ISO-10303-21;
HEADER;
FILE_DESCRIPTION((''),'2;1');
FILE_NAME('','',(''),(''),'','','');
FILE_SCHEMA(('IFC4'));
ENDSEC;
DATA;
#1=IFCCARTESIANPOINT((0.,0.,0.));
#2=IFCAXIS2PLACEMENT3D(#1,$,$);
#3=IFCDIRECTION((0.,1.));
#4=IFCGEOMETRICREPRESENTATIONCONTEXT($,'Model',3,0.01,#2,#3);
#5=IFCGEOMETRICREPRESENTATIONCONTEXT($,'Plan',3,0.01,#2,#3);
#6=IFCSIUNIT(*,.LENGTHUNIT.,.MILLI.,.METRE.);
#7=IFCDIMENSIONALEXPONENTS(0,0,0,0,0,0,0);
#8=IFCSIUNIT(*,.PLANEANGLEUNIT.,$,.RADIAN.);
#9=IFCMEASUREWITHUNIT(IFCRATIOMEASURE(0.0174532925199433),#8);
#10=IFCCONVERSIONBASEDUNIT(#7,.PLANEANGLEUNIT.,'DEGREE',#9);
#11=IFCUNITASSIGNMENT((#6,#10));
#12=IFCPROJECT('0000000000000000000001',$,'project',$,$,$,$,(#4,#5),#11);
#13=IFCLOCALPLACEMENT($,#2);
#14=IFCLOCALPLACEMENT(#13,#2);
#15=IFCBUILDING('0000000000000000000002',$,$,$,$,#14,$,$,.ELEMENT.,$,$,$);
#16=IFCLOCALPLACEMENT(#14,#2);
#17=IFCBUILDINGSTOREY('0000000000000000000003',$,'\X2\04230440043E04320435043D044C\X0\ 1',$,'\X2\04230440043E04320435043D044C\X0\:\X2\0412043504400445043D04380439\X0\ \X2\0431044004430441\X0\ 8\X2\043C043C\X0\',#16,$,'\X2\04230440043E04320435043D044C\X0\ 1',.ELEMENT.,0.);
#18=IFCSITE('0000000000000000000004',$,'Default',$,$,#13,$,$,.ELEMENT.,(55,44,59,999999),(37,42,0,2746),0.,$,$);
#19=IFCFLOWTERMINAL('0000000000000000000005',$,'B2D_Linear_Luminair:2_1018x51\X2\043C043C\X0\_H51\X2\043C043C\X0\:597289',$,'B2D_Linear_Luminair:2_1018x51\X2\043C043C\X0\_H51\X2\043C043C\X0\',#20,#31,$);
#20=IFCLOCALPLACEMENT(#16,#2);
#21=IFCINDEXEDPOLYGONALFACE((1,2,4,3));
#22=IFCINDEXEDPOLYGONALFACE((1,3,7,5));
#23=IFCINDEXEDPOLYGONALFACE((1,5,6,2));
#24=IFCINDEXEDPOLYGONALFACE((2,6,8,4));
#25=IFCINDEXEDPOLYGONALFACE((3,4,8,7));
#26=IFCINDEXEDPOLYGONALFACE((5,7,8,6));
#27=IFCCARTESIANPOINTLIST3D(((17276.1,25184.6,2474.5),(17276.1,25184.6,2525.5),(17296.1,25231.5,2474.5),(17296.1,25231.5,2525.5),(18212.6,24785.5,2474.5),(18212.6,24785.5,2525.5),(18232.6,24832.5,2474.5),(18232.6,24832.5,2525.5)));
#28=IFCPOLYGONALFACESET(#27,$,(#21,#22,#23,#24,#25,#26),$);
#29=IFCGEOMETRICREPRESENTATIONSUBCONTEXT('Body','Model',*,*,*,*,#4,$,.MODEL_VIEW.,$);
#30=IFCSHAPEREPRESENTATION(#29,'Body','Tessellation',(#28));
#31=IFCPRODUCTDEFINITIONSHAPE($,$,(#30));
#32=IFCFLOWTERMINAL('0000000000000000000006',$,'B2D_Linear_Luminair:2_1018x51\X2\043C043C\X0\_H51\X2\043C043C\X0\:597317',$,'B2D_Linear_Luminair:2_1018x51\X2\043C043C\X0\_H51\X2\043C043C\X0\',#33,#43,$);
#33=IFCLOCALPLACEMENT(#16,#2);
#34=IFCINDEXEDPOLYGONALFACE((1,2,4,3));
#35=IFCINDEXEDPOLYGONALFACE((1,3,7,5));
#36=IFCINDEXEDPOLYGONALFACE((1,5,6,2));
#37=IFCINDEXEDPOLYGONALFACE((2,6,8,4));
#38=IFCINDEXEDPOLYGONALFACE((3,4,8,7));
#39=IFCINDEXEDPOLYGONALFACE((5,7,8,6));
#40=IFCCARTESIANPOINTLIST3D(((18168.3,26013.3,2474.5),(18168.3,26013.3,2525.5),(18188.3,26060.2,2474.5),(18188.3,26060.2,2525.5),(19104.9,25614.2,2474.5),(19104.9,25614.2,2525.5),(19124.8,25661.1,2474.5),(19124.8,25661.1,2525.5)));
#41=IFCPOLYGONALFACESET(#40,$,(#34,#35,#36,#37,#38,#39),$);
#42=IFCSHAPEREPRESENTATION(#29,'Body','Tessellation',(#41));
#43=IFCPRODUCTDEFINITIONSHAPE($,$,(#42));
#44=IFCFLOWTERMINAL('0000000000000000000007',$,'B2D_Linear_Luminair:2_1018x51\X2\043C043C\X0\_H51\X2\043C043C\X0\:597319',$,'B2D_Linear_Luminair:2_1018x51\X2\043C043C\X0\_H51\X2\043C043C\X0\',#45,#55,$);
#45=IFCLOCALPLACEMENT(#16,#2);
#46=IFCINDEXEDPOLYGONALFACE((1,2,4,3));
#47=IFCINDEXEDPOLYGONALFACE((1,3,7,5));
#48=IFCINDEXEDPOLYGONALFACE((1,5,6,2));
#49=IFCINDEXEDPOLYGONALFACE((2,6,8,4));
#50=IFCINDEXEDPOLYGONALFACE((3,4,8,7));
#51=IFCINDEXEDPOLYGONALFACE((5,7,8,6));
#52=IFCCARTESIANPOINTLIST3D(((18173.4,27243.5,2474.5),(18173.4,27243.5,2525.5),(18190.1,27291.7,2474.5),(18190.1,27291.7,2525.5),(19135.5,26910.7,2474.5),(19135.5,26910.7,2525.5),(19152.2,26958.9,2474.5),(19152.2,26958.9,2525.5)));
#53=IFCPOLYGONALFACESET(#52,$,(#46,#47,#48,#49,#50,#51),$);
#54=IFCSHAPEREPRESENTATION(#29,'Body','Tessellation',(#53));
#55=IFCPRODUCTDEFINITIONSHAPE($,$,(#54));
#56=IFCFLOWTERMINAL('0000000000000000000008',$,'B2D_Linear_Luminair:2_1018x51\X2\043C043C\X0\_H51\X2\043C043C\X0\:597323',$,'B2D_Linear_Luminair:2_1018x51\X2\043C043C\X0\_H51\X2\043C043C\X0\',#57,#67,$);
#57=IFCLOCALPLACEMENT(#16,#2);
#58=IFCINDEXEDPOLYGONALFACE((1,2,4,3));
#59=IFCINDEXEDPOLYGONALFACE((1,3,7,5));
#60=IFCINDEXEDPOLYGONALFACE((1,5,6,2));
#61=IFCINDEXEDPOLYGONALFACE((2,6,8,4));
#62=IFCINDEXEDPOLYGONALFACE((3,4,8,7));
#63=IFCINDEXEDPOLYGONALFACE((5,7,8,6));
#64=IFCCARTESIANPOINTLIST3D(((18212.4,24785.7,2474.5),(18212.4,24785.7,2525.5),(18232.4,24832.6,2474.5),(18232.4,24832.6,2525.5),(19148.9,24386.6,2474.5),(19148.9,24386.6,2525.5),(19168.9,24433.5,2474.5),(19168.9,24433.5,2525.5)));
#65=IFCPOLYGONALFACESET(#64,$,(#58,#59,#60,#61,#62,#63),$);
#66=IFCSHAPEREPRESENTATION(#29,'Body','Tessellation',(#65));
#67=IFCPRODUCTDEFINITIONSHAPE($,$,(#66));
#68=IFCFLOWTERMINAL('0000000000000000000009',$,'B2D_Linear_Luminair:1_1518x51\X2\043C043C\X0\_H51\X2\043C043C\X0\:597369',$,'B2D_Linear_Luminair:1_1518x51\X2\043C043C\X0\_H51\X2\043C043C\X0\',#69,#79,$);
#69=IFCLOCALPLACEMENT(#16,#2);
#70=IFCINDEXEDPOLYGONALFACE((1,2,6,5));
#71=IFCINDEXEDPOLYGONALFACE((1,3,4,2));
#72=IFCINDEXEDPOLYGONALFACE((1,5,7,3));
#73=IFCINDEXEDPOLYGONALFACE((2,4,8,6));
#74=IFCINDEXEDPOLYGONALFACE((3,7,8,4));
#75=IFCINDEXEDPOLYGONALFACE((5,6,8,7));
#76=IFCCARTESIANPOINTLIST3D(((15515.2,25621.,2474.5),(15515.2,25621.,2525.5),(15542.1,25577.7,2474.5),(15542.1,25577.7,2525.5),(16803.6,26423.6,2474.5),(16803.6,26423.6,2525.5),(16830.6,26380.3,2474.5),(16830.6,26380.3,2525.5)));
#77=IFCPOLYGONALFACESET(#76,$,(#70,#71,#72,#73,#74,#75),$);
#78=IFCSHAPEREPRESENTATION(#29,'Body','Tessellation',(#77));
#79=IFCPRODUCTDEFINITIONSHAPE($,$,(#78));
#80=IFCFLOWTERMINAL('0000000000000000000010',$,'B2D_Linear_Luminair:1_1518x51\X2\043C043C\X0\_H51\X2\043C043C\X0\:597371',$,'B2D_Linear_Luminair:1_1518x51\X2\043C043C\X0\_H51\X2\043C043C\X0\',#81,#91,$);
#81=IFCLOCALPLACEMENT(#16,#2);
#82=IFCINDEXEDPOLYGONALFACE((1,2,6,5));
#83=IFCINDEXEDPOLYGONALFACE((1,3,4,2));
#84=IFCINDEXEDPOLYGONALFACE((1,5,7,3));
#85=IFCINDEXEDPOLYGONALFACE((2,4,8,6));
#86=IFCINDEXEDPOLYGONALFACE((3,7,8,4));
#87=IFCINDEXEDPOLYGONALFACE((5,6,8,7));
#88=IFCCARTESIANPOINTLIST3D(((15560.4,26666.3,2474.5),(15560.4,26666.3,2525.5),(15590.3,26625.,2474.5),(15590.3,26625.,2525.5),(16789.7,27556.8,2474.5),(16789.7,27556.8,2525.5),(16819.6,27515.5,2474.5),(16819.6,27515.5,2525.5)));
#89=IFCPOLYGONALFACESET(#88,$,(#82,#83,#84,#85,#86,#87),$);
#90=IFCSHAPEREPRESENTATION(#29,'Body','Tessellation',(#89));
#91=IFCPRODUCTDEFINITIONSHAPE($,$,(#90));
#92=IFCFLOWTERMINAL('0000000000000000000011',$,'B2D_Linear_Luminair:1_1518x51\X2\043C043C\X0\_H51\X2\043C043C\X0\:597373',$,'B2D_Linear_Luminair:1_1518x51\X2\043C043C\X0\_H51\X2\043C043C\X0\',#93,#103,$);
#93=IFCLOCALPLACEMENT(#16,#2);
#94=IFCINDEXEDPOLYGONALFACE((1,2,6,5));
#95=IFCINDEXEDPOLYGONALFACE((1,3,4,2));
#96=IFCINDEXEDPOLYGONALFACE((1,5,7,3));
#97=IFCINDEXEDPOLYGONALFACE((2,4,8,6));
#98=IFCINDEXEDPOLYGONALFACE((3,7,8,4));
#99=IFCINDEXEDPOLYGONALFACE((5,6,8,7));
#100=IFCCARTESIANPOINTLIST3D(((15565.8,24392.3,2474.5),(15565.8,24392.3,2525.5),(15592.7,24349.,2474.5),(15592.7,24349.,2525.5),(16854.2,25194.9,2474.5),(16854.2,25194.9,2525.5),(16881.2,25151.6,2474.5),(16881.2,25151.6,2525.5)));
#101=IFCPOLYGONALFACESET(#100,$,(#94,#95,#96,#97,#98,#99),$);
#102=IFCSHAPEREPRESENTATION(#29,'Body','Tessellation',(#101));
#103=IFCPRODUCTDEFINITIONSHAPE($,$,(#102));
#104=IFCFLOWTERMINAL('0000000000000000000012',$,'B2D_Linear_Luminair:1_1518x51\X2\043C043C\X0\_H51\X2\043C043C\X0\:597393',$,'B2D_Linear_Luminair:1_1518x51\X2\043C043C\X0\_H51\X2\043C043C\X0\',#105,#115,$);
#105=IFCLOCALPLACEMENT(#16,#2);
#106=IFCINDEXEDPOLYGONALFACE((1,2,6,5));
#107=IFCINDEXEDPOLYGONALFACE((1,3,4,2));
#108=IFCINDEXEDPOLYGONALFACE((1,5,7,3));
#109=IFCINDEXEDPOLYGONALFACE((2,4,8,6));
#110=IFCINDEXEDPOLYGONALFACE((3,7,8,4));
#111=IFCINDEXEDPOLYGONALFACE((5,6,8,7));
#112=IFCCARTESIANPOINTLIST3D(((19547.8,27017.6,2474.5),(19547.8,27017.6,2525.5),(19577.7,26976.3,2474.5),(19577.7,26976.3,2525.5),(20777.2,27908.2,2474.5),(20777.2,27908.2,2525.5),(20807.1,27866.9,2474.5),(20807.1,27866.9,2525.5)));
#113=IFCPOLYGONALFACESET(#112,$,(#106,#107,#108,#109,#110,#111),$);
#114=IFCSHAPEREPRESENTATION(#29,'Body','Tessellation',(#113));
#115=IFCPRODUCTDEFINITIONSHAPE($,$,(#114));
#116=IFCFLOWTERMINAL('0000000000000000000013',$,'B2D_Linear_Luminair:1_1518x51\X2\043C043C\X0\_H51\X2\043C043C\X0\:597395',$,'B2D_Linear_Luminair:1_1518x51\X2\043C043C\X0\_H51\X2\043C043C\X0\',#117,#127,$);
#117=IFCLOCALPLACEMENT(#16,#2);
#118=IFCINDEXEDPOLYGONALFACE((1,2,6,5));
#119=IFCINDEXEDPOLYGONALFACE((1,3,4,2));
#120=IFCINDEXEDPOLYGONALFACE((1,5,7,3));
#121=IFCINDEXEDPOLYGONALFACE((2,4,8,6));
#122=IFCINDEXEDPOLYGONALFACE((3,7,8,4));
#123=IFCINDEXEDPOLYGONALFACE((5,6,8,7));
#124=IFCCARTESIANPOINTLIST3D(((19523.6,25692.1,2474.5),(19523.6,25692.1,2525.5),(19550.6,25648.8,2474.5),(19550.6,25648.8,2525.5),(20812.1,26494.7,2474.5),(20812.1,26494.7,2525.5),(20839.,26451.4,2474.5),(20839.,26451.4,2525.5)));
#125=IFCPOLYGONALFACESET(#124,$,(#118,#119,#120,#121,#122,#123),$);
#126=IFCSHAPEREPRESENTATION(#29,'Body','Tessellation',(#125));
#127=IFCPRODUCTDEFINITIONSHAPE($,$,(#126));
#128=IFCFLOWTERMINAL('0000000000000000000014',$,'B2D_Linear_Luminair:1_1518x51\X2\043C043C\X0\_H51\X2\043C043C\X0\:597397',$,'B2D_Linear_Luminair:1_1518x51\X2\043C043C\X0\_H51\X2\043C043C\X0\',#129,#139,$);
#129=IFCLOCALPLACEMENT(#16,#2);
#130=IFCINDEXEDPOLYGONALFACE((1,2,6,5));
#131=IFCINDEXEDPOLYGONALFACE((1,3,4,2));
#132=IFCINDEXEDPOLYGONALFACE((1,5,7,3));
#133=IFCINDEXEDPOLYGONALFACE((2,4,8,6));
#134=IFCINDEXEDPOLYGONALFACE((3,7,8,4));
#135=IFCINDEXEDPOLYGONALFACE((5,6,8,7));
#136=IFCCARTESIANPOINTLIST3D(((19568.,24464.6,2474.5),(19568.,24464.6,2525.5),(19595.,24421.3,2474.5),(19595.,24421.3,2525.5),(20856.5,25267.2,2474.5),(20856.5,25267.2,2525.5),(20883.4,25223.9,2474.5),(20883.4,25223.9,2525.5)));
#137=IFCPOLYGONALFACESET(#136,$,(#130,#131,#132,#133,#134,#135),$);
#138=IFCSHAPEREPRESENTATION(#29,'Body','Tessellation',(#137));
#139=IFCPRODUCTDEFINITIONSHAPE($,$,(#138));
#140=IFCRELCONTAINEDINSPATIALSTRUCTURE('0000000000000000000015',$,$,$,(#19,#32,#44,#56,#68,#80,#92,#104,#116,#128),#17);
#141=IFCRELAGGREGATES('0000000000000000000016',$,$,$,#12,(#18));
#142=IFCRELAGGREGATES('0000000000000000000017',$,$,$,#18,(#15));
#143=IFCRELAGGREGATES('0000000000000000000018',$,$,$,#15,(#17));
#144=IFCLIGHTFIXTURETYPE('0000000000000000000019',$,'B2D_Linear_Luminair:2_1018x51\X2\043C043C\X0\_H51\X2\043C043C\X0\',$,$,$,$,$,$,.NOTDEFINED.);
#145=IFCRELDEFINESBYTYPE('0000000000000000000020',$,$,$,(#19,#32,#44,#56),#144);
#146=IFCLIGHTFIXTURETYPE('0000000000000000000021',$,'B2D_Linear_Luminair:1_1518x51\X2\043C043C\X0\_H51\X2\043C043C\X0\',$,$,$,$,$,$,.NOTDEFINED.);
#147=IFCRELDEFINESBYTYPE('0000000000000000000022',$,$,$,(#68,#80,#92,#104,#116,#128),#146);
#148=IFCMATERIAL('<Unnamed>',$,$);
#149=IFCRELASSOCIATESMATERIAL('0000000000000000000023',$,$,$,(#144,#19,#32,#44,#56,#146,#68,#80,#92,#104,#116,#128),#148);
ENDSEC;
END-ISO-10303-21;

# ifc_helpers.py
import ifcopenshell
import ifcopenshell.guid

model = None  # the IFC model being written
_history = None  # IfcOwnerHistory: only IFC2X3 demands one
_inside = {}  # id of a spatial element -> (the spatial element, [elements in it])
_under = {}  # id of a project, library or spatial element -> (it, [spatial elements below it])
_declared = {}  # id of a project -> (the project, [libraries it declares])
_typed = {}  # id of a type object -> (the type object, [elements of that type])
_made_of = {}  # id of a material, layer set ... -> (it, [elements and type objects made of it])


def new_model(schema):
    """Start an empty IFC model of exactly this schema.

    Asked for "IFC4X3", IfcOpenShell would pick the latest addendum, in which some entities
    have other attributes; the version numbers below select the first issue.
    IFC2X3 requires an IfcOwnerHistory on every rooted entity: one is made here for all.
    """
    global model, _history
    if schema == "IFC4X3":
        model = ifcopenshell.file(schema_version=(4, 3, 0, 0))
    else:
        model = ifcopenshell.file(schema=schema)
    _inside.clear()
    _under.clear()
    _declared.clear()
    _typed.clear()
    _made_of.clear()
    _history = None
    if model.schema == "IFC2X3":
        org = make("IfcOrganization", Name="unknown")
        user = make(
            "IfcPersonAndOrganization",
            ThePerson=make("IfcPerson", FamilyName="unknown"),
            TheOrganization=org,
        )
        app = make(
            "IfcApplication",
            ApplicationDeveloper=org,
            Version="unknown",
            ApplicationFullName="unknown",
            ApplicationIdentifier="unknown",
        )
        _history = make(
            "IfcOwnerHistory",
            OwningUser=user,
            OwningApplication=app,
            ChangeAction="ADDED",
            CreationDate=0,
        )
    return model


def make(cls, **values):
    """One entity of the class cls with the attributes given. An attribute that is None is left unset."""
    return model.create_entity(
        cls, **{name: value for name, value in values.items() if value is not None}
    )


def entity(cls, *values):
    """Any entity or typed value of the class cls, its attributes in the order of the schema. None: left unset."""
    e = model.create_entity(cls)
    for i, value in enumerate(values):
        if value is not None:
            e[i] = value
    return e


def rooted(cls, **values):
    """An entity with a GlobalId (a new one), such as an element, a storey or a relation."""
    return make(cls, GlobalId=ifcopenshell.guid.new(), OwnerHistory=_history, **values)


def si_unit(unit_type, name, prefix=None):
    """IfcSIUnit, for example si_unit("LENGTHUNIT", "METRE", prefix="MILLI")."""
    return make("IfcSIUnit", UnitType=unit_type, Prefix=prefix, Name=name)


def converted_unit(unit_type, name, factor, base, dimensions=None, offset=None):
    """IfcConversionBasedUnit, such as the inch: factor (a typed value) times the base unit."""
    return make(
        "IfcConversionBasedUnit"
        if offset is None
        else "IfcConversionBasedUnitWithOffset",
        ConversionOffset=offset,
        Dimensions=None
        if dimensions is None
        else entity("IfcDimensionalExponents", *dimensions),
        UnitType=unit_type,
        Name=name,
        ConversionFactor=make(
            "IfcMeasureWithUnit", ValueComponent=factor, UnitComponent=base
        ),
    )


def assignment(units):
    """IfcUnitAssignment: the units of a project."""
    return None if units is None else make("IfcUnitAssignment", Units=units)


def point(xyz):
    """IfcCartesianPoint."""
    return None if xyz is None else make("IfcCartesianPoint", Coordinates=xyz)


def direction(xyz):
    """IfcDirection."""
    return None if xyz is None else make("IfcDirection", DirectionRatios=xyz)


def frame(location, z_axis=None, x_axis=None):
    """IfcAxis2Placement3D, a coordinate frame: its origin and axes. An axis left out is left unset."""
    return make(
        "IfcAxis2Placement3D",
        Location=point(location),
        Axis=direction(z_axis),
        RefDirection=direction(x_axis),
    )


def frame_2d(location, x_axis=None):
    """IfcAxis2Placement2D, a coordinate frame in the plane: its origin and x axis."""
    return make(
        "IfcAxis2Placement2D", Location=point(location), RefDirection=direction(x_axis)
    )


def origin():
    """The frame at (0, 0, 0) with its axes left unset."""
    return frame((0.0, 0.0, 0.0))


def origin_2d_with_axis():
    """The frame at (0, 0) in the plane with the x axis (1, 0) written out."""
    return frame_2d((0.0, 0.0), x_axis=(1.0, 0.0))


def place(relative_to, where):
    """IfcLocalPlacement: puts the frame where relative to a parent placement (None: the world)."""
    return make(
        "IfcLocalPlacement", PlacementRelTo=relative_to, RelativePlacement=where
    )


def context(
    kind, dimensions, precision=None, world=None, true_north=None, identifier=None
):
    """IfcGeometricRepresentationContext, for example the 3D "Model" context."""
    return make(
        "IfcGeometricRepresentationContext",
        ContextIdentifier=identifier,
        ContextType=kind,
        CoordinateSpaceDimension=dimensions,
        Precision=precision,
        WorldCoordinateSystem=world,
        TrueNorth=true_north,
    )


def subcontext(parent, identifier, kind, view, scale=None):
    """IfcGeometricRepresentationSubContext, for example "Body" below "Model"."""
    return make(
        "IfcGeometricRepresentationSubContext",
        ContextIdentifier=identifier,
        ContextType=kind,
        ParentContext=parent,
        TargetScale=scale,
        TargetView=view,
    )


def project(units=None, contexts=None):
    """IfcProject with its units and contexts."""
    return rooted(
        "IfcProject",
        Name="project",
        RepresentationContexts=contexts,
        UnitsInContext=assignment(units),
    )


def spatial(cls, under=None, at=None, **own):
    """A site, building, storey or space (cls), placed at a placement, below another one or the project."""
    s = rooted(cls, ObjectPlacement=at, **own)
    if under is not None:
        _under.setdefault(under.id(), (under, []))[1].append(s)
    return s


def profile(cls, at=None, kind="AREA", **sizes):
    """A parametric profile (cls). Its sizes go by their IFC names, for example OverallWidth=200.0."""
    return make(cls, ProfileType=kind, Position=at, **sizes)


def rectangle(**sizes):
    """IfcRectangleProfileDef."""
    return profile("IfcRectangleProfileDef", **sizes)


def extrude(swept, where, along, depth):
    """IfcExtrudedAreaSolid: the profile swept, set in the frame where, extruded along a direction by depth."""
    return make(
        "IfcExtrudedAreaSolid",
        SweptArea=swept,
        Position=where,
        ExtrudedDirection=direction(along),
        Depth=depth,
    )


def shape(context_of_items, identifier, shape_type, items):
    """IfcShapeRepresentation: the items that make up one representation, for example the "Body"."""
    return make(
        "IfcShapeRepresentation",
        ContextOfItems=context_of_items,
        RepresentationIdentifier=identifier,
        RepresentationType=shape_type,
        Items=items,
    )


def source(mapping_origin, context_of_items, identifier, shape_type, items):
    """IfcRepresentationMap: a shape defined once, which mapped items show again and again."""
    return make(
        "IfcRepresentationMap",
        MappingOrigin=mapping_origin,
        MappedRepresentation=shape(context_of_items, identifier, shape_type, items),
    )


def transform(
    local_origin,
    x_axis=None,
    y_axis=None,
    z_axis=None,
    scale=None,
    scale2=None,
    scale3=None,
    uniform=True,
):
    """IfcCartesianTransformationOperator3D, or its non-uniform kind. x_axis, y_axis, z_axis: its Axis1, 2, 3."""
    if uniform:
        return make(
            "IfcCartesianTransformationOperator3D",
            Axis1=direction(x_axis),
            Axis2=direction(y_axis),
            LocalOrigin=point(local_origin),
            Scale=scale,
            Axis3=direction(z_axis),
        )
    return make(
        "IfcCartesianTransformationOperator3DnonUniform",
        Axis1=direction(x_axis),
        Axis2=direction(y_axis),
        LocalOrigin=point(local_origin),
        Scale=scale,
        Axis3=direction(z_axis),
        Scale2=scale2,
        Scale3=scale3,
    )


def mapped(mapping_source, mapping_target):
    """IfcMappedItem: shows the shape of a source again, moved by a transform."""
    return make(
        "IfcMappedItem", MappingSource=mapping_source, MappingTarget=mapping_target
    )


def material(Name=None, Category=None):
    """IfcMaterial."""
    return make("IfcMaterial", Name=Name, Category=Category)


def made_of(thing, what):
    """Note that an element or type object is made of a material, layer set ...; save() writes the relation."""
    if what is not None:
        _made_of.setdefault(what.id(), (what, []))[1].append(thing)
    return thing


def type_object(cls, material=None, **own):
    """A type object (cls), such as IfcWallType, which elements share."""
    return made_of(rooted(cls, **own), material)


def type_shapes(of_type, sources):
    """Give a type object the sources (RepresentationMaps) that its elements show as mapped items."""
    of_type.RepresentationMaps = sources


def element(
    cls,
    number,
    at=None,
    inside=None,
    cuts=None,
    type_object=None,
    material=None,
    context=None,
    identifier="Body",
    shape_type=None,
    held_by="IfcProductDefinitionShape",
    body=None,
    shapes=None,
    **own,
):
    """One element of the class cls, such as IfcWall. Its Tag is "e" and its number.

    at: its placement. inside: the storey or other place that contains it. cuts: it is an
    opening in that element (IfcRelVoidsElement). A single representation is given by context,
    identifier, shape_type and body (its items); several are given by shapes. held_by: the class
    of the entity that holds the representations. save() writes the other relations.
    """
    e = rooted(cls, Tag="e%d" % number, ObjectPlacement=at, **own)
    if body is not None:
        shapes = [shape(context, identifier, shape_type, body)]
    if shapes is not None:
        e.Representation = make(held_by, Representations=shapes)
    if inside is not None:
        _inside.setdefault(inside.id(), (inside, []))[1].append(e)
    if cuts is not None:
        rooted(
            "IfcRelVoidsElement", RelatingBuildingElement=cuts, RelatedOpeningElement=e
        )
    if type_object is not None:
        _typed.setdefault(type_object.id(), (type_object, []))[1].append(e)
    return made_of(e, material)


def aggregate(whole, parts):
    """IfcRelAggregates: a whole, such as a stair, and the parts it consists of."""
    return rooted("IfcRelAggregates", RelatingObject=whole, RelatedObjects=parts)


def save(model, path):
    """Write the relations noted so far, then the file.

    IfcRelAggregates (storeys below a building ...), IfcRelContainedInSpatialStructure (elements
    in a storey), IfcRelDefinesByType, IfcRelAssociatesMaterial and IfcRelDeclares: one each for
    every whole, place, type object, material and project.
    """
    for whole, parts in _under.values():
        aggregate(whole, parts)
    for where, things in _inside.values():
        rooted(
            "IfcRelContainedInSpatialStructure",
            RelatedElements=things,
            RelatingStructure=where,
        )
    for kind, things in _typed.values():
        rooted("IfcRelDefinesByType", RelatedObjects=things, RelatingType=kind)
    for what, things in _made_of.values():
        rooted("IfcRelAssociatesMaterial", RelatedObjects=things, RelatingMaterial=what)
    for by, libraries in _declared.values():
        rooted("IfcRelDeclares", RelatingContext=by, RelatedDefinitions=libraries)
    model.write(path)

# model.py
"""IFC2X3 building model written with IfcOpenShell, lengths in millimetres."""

from ifc_helpers import new_model, entity, si_unit, converted_unit, direction, frame, origin, origin_2d_with_axis, place, context, subcontext, project, spatial, rectangle, extrude, source, transform, mapped, material, type_object, type_shapes, element, save


model = new_model("IFC2X3")

# Units and contexts
model_context = context("Model", 3, precision=0.01, world=origin(), true_north=direction((0.0, 1.0)))
plan_context = context("Plan", 3, precision=0.01, world=origin(), true_north=direction((0.0, 1.0)))
body_context = subcontext(model_context, "Body", "Model", "MODEL_VIEW")
ifc_project = project(units=[si_unit("LENGTHUNIT", "METRE", prefix="MILLI"), converted_unit("PLANEANGLEUNIT", "DEGREE", entity("IfcRatioMeasure", 0.0174532925199433), si_unit("PLANEANGLEUNIT", "RADIAN"), dimensions=[0, 0, 0, 0, 0, 0, 0])], contexts=[model_context, plan_context])

# Site, building, storey
site_placement = place(None, origin())
site = spatial("IfcSite", under=ifc_project, at=site_placement, Name="Default", CompositionType="ELEMENT", RefLatitude=(55, 44, 59, 999999), RefLongitude=(37, 42, 0, 2746), RefElevation=0.0)
building_placement = place(site_placement, origin())
building = spatial("IfcBuilding", under=site, at=building_placement, CompositionType="ELEMENT")
storey_placement = place(building_placement, origin())
storey = spatial("IfcBuildingStorey", under=building, at=storey_placement, Name="Уровень 1", ObjectType="Уровень:Верхний брус 8мм", LongName="Уровень 1", CompositionType="ELEMENT", Elevation=0.0)

# Flow terminals
ifc_material = material(Name="<Unnamed>")
light_fixture_type_1 = type_object("IfcLightFixtureType", Name="B2D_Linear_Luminair:2_1018x51мм_H51мм", PredefinedType="NOTDEFINED", material=ifc_material)
shared_shape_1 = source(origin(), body_context, "Body", "SweptSolid", [
    extrude(rectangle(XDim=1018.0, YDim=51.0, at=origin_2d_with_axis()), frame((0.0, 0.0, 0.0), z_axis=(0.0, 0.0, 1.0), x_axis=(-1.0, 0.0, 0.0)), (0.0, 0.0, 1.0), 51.0),
])
type_shapes(light_fixture_type_1, [shared_shape_1])
for number, where, z_axis, x_axis, name in (
    (1, (17754.3, 25008.5, 2525.5), (0.0, 0.0, -1.0), (0.919958, -0.392016, 0.0), "B2D_Linear_Luminair:2_1018x51мм_H51мм:597289"),
    (2, (18646.6, 25837.2, 2525.5), (0.0, 0.0, -1.0), (0.919958, -0.392016, 0.0), "B2D_Linear_Luminair:2_1018x51мм_H51мм:597317"),
    (3, (18662.8, 27101.2, 2525.5), (0.0, 0.0, -1.0), (0.945063, -0.326888, 0.0), "B2D_Linear_Luminair:2_1018x51мм_H51мм:597319"),
    (4, (18690.6, 24609.6, 2525.5), (0.0, 0.0, -1.0), (0.919958, -0.392016, 0.0), "B2D_Linear_Luminair:2_1018x51мм_H51мм:597323"),
):
    element("IfcFlowTerminal", number, at=place(storey_placement, frame(where, z_axis=z_axis, x_axis=x_axis)), inside=storey, type_object=light_fixture_type_1, material=ifc_material, Name=name, ObjectType="B2D_Linear_Luminair:2_1018x51мм_H51мм", context=body_context, shape_type="MappedRepresentation", body=[
        mapped(shared_shape_1, transform((0.0, 0.0, 0.0), scale=1.0)),
    ])
light_fixture_type_2 = type_object("IfcLightFixtureType", Name="B2D_Linear_Luminair:1_1518x51мм_H51мм", PredefinedType="NOTDEFINED", material=ifc_material)
shared_shape_2 = source(origin(), body_context, "Body", "SweptSolid", [
    extrude(rectangle(XDim=1518.0, YDim=51.0, at=origin_2d_with_axis()), frame((0.0, 0.0, 0.0), z_axis=(0.0, 0.0, 1.0), x_axis=(-1.0, 0.0, 0.0)), (0.0, 0.0, 1.0), 51.0),
])
type_shapes(light_fixture_type_2, [shared_shape_2])
for number, where, z_axis, x_axis, name in (
    (5, (16172.9, 26000.6, 2525.5), (0.0, 0.0, -1.0), (0.848787, 0.528735, 0.0), "B2D_Linear_Luminair:1_1518x51мм_H51мм:597369"),
    (6, (16190.0, 27090.9, 2525.5), (0.0, 0.0, -1.0), (0.809837, 0.586655, 0.0), "B2D_Linear_Luminair:1_1518x51мм_H51мм:597371"),
    (7, (16223.5, 24771.9, 2525.5), (0.0, 0.0, -1.0), (0.848787, 0.528735, 0.0), "B2D_Linear_Luminair:1_1518x51мм_H51мм:597373"),
    (8, (20177.5, 27442.3, 2525.5), (0.0, 0.0, -1.0), (0.809837, 0.586655, 0.0), "B2D_Linear_Luminair:1_1518x51мм_H51мм:597393"),
    (9, (20181.3, 26071.8, 2525.5), (0.0, 0.0, -1.0), (0.848787, 0.528735, 0.0), "B2D_Linear_Luminair:1_1518x51мм_H51мм:597395"),
    (10, (20225.7, 24844.3, 2525.5), (0.0, 0.0, -1.0), (0.848787, 0.528735, 0.0), "B2D_Linear_Luminair:1_1518x51мм_H51мм:597397"),
):
    element("IfcFlowTerminal", number, at=place(storey_placement, frame(where, z_axis=z_axis, x_axis=x_axis)), inside=storey, type_object=light_fixture_type_2, material=ifc_material, Name=name, ObjectType="B2D_Linear_Luminair:1_1518x51мм_H51мм", context=body_context, shape_type="MappedRepresentation", body=[
        mapped(shared_shape_2, transform((0.0, 0.0, 0.0), scale=1.0)),
    ])

save(model, "model.ifc")
